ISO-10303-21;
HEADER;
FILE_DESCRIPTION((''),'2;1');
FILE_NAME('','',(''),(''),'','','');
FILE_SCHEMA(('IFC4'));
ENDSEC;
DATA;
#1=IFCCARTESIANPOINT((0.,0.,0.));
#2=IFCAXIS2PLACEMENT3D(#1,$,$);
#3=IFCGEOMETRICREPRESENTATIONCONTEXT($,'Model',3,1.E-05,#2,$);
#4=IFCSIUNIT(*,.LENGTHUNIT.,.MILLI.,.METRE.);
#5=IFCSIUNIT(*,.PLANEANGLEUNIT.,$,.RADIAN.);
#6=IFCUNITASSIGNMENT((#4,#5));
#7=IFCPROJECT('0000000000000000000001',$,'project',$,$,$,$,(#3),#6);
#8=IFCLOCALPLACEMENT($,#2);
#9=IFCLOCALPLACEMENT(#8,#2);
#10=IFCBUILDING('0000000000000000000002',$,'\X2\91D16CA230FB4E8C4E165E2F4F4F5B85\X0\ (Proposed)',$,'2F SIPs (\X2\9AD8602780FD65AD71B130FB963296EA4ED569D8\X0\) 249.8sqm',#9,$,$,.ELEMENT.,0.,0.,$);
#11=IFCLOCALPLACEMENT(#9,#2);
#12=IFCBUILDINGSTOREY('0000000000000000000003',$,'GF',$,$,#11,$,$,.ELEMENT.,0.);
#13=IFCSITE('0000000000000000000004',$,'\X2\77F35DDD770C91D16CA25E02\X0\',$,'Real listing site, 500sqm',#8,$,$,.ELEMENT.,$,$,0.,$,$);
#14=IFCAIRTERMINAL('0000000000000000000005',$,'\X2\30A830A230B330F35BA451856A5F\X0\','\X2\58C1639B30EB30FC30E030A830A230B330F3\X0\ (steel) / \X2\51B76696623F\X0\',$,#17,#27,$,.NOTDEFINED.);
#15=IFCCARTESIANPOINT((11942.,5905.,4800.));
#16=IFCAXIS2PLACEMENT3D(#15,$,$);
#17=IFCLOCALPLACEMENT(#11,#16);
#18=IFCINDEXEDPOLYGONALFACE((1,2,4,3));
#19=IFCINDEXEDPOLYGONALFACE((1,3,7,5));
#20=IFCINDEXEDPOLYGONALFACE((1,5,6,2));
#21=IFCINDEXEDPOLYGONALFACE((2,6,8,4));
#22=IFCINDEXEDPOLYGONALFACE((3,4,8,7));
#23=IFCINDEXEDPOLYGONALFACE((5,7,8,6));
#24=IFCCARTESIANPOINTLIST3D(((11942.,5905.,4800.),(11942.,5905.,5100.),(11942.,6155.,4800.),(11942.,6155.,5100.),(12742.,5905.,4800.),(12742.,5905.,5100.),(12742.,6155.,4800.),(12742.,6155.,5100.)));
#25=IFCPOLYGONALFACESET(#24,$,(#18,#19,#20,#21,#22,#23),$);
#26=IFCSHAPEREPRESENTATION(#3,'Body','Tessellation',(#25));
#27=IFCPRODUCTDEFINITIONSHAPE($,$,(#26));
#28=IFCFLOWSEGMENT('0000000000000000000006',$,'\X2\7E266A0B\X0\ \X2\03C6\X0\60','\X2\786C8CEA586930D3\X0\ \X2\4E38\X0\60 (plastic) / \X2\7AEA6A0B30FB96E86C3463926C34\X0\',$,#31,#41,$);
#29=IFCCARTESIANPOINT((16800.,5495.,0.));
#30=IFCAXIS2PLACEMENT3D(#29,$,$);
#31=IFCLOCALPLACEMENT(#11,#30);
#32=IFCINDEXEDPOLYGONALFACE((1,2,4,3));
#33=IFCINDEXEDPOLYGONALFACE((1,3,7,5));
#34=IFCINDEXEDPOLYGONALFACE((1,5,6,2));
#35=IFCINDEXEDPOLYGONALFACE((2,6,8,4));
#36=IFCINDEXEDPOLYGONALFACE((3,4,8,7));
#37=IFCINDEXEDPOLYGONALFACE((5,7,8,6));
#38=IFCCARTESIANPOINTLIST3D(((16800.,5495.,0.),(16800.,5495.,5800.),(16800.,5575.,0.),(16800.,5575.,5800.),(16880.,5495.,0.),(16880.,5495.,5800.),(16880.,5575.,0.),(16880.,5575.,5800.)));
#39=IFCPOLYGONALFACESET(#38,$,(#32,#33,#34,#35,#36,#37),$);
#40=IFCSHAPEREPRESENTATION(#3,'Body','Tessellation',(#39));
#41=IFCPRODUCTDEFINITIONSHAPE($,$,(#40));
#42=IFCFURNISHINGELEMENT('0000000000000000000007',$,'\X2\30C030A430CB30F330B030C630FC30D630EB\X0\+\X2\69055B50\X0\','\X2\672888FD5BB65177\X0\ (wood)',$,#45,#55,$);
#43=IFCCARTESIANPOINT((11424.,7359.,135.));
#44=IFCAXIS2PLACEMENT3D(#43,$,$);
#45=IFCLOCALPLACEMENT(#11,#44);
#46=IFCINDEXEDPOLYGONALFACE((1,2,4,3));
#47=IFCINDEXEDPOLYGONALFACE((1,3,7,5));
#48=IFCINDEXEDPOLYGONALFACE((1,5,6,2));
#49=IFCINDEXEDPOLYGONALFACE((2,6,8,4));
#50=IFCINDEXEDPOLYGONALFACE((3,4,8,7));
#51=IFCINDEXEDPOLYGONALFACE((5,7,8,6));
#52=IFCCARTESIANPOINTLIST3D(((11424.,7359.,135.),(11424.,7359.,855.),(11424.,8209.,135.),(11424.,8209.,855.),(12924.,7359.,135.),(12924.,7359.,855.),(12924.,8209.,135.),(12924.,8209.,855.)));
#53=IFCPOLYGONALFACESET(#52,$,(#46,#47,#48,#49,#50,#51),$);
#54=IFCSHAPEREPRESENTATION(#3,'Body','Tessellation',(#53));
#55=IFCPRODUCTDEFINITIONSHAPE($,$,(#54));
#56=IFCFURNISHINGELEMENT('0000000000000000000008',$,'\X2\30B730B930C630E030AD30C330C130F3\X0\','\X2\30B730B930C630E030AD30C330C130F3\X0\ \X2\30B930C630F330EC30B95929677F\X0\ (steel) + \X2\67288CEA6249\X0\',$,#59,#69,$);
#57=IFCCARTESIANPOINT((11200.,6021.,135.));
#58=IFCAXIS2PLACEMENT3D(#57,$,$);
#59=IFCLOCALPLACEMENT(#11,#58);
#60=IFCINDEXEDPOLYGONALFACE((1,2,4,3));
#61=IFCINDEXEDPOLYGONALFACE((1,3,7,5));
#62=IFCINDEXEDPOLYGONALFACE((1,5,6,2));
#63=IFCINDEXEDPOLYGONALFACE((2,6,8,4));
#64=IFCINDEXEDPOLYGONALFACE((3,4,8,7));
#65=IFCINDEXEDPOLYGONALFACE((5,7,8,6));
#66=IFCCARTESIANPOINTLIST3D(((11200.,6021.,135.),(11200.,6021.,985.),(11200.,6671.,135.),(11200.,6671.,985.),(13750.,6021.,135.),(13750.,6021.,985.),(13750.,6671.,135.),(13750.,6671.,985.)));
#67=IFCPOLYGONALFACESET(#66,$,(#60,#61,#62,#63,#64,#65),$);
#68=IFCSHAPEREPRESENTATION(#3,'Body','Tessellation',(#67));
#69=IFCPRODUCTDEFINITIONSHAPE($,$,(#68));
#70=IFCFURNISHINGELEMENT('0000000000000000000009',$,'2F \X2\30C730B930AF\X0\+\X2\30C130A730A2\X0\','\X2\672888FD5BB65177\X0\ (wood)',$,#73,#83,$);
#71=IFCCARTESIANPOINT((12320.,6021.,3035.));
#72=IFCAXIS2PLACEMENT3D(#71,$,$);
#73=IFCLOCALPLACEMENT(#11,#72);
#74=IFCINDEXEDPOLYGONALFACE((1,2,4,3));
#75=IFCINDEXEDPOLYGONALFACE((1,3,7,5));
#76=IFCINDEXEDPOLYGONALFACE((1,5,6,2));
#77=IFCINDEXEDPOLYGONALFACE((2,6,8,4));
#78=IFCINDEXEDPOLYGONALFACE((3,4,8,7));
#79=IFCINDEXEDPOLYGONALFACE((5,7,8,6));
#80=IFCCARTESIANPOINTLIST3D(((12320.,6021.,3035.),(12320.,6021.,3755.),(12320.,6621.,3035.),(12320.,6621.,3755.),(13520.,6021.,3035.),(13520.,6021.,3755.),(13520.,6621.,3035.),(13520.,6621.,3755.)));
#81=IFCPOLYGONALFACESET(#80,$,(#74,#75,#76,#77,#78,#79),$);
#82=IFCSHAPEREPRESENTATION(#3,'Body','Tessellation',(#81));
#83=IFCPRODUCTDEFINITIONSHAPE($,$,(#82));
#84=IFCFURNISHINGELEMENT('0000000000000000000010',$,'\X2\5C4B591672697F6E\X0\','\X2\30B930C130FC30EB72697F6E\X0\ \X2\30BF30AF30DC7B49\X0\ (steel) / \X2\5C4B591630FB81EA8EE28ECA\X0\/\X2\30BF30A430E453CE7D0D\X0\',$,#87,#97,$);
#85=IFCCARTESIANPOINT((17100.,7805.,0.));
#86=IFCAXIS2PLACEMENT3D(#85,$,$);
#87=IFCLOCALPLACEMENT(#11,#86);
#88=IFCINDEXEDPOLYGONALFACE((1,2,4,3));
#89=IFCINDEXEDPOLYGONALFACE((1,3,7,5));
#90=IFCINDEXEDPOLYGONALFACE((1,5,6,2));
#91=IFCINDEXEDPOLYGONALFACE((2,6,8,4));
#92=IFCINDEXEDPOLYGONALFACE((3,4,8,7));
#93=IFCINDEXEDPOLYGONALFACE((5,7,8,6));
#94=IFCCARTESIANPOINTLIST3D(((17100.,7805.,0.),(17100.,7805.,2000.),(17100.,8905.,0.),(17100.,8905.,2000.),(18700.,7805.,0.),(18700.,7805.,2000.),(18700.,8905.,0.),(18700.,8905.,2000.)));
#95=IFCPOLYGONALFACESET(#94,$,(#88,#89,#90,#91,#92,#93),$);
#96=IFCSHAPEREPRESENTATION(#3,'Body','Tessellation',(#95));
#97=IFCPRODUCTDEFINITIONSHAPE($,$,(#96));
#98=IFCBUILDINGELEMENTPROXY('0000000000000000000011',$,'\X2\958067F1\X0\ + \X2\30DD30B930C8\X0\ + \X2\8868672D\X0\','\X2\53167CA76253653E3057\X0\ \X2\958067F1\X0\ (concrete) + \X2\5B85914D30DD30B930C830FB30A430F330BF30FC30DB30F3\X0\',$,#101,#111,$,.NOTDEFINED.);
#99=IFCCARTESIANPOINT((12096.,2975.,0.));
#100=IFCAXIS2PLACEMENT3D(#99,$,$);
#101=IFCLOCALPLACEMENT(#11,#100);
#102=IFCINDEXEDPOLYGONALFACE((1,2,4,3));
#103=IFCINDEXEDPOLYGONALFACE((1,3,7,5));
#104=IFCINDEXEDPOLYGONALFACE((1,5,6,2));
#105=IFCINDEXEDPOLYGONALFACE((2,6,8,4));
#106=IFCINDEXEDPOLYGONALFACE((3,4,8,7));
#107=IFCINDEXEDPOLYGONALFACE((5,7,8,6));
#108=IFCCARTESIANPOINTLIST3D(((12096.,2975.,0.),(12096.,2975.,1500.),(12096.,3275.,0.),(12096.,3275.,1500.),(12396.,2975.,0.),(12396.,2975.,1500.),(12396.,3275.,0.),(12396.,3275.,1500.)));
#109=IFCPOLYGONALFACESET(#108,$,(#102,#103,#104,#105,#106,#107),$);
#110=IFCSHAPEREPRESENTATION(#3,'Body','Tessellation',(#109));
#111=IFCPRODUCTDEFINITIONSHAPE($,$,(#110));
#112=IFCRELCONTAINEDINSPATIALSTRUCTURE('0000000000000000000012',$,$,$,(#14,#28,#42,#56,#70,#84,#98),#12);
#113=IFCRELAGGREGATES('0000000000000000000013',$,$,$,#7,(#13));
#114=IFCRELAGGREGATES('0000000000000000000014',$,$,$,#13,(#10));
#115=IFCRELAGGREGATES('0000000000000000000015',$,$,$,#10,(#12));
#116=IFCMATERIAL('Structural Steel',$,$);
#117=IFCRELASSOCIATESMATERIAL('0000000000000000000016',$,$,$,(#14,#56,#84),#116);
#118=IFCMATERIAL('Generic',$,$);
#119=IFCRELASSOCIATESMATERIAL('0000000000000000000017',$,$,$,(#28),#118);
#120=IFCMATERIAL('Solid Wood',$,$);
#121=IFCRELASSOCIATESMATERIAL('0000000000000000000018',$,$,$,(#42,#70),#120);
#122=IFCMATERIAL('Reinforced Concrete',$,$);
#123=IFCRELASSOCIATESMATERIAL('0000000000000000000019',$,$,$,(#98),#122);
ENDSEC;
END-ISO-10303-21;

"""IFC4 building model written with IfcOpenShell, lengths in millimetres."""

from ifc_helpers import new_model, si_unit, frame, frame_2d, origin, place, context, project, spatial, rectangle, extrude, material, element, save


model = new_model("IFC4")

# Units and contexts
model_context = context("Model", 3, precision=1e-05, world=origin())
ifc_project = project(units=[si_unit("LENGTHUNIT", "METRE", prefix="MILLI"), si_unit("PLANEANGLEUNIT", "RADIAN")], contexts=[model_context])

# Site, building, storey
site_placement = place(None, origin())
site = spatial("IfcSite", under=ifc_project, at=site_placement, Name="石川県金沢市", ObjectType="Real listing site, 500sqm", CompositionType="ELEMENT", RefElevation=0.0)
building_placement = place(site_placement, origin())
building = spatial("IfcBuilding", under=site, at=building_placement, Name="金沢・二世帯住宅 (Proposed)", ObjectType="2F SIPs (高性能断熱・防雪仕様) 249.8sqm", CompositionType="ELEMENT", ElevationOfRefHeight=0.0, ElevationOfTerrain=0.0)
storey_placement = place(building_placement, origin())
storey = spatial("IfcBuildingStorey", under=building, at=storey_placement, Name="GF", CompositionType="ELEMENT", Elevation=0.0)

# Shared definitions
ifc_material_1 = material(Name="Solid Wood")

# Shared definitions
ifc_material_2 = material(Name="Reinforced Concrete")

# Shared definitions
ifc_material_3 = material(Name="Structural Steel")

# Shared definitions
ifc_material_4 = material(Name="Generic")

# Air terminal
air_terminal_placement = place(storey_placement, frame((11942.0, 5905.0, 4800.0)))
element("IfcAirTerminal", 1, at=air_terminal_placement, inside=storey, material=ifc_material_3, Name="エアコン室内機", Description="壁掛ルームエアコン (steel) / 冷暖房", PredefinedType="NOTDEFINED", context=model_context, shape_type="SweptSolid", body=[
    extrude(rectangle(XDim=800.0, YDim=250.0, at=frame_2d((400.0, 125.0))), frame((11942.0, 5905.0, 4800.0)), (0.0, 0.0, 1.0), 300.0),
])

# Flow segment
flow_segment_placement = place(storey_placement, frame((16800.0, 5495.0, 0.0)))
element("IfcFlowSegment", 2, at=flow_segment_placement, inside=storey, material=ifc_material_4, Name="縦樋 φ60", Description="硬質塩ビ 丸60 (plastic) / 竪樋・雨水排水", context=model_context, shape_type="SweptSolid", body=[
    extrude(rectangle(XDim=80.0, YDim=80.0, at=frame_2d((40.0, 40.0))), frame((16800.0, 5495.0, 0.0)), (0.0, 0.0, 1.0), 5800.0),
])

# Furnishing elements
furnishing_1_placement = place(storey_placement, frame((11424.0, 7359.0, 135.0)))
element("IfcFurnishingElement", 3, at=furnishing_1_placement, inside=storey, material=ifc_material_1, Name="ダイニングテーブル+椅子", Description="木製家具 (wood)", context=model_context, shape_type="SweptSolid", body=[
    extrude(rectangle(XDim=1500.0, YDim=850.0, at=frame_2d((750.0, 425.0))), frame((11424.0, 7359.0, 135.0)), (0.0, 0.0, 1.0), 720.0),
])
furnishing_2_placement = place(storey_placement, frame((11200.0, 6021.0, 135.0)))
element("IfcFurnishingElement", 4, at=furnishing_2_placement, inside=storey, material=ifc_material_3, Name="システムキッチン", Description="システムキッチン ステンレス天板 (steel) + 木質扉", context=model_context, shape_type="SweptSolid", body=[
    extrude(rectangle(XDim=2550.0, YDim=650.0, at=frame_2d((1275.0, 325.0))), frame((11200.0, 6021.0, 135.0)), (0.0, 0.0, 1.0), 850.0),
])
furnishing_3_placement = place(storey_placement, frame((12320.0, 6021.0, 3035.0)))
element("IfcFurnishingElement", 5, at=furnishing_3_placement, inside=storey, material=ifc_material_1, Name="2F デスク+チェア", Description="木製家具 (wood)", context=model_context, shape_type="SweptSolid", body=[
    extrude(rectangle(XDim=1200.0, YDim=600.0, at=frame_2d((600.0, 300.0))), frame((12320.0, 6021.0, 3035.0)), (0.0, 0.0, 1.0), 720.0),
])
furnishing_4_placement = place(storey_placement, frame((17100.0, 7805.0, 0.0)))
element("IfcFurnishingElement", 6, at=furnishing_4_placement, inside=storey, material=ifc_material_3, Name="屋外物置", Description="スチール物置 タクボ等 (steel) / 屋外・自転車/タイヤ収納", context=model_context, shape_type="SweptSolid", body=[
    extrude(rectangle(XDim=1600.0, YDim=1100.0, at=frame_2d((800.0, 550.0))), frame((17100.0, 7805.0, 0.0)), (0.0, 0.0, 1.0), 2000.0),
])

# Building element proxy
proxy_placement = place(storey_placement, frame((12096.0, 2975.0, 0.0)))
element("IfcBuildingElementProxy", 7, at=proxy_placement, inside=storey, material=ifc_material_2, Name="門柱 + ポスト + 表札", Description="化粧打放し 門柱 (concrete) + 宅配ポスト・インターホン", PredefinedType="NOTDEFINED", context=model_context, shape_type="SweptSolid", body=[
    extrude(rectangle(XDim=300.0, YDim=300.0, at=frame_2d((150.0, 150.0))), frame((12096.0, 2975.0, 0.0)), (0.0, 0.0, 1.0), 1500.0),
])

save(model, "model.ifc")
